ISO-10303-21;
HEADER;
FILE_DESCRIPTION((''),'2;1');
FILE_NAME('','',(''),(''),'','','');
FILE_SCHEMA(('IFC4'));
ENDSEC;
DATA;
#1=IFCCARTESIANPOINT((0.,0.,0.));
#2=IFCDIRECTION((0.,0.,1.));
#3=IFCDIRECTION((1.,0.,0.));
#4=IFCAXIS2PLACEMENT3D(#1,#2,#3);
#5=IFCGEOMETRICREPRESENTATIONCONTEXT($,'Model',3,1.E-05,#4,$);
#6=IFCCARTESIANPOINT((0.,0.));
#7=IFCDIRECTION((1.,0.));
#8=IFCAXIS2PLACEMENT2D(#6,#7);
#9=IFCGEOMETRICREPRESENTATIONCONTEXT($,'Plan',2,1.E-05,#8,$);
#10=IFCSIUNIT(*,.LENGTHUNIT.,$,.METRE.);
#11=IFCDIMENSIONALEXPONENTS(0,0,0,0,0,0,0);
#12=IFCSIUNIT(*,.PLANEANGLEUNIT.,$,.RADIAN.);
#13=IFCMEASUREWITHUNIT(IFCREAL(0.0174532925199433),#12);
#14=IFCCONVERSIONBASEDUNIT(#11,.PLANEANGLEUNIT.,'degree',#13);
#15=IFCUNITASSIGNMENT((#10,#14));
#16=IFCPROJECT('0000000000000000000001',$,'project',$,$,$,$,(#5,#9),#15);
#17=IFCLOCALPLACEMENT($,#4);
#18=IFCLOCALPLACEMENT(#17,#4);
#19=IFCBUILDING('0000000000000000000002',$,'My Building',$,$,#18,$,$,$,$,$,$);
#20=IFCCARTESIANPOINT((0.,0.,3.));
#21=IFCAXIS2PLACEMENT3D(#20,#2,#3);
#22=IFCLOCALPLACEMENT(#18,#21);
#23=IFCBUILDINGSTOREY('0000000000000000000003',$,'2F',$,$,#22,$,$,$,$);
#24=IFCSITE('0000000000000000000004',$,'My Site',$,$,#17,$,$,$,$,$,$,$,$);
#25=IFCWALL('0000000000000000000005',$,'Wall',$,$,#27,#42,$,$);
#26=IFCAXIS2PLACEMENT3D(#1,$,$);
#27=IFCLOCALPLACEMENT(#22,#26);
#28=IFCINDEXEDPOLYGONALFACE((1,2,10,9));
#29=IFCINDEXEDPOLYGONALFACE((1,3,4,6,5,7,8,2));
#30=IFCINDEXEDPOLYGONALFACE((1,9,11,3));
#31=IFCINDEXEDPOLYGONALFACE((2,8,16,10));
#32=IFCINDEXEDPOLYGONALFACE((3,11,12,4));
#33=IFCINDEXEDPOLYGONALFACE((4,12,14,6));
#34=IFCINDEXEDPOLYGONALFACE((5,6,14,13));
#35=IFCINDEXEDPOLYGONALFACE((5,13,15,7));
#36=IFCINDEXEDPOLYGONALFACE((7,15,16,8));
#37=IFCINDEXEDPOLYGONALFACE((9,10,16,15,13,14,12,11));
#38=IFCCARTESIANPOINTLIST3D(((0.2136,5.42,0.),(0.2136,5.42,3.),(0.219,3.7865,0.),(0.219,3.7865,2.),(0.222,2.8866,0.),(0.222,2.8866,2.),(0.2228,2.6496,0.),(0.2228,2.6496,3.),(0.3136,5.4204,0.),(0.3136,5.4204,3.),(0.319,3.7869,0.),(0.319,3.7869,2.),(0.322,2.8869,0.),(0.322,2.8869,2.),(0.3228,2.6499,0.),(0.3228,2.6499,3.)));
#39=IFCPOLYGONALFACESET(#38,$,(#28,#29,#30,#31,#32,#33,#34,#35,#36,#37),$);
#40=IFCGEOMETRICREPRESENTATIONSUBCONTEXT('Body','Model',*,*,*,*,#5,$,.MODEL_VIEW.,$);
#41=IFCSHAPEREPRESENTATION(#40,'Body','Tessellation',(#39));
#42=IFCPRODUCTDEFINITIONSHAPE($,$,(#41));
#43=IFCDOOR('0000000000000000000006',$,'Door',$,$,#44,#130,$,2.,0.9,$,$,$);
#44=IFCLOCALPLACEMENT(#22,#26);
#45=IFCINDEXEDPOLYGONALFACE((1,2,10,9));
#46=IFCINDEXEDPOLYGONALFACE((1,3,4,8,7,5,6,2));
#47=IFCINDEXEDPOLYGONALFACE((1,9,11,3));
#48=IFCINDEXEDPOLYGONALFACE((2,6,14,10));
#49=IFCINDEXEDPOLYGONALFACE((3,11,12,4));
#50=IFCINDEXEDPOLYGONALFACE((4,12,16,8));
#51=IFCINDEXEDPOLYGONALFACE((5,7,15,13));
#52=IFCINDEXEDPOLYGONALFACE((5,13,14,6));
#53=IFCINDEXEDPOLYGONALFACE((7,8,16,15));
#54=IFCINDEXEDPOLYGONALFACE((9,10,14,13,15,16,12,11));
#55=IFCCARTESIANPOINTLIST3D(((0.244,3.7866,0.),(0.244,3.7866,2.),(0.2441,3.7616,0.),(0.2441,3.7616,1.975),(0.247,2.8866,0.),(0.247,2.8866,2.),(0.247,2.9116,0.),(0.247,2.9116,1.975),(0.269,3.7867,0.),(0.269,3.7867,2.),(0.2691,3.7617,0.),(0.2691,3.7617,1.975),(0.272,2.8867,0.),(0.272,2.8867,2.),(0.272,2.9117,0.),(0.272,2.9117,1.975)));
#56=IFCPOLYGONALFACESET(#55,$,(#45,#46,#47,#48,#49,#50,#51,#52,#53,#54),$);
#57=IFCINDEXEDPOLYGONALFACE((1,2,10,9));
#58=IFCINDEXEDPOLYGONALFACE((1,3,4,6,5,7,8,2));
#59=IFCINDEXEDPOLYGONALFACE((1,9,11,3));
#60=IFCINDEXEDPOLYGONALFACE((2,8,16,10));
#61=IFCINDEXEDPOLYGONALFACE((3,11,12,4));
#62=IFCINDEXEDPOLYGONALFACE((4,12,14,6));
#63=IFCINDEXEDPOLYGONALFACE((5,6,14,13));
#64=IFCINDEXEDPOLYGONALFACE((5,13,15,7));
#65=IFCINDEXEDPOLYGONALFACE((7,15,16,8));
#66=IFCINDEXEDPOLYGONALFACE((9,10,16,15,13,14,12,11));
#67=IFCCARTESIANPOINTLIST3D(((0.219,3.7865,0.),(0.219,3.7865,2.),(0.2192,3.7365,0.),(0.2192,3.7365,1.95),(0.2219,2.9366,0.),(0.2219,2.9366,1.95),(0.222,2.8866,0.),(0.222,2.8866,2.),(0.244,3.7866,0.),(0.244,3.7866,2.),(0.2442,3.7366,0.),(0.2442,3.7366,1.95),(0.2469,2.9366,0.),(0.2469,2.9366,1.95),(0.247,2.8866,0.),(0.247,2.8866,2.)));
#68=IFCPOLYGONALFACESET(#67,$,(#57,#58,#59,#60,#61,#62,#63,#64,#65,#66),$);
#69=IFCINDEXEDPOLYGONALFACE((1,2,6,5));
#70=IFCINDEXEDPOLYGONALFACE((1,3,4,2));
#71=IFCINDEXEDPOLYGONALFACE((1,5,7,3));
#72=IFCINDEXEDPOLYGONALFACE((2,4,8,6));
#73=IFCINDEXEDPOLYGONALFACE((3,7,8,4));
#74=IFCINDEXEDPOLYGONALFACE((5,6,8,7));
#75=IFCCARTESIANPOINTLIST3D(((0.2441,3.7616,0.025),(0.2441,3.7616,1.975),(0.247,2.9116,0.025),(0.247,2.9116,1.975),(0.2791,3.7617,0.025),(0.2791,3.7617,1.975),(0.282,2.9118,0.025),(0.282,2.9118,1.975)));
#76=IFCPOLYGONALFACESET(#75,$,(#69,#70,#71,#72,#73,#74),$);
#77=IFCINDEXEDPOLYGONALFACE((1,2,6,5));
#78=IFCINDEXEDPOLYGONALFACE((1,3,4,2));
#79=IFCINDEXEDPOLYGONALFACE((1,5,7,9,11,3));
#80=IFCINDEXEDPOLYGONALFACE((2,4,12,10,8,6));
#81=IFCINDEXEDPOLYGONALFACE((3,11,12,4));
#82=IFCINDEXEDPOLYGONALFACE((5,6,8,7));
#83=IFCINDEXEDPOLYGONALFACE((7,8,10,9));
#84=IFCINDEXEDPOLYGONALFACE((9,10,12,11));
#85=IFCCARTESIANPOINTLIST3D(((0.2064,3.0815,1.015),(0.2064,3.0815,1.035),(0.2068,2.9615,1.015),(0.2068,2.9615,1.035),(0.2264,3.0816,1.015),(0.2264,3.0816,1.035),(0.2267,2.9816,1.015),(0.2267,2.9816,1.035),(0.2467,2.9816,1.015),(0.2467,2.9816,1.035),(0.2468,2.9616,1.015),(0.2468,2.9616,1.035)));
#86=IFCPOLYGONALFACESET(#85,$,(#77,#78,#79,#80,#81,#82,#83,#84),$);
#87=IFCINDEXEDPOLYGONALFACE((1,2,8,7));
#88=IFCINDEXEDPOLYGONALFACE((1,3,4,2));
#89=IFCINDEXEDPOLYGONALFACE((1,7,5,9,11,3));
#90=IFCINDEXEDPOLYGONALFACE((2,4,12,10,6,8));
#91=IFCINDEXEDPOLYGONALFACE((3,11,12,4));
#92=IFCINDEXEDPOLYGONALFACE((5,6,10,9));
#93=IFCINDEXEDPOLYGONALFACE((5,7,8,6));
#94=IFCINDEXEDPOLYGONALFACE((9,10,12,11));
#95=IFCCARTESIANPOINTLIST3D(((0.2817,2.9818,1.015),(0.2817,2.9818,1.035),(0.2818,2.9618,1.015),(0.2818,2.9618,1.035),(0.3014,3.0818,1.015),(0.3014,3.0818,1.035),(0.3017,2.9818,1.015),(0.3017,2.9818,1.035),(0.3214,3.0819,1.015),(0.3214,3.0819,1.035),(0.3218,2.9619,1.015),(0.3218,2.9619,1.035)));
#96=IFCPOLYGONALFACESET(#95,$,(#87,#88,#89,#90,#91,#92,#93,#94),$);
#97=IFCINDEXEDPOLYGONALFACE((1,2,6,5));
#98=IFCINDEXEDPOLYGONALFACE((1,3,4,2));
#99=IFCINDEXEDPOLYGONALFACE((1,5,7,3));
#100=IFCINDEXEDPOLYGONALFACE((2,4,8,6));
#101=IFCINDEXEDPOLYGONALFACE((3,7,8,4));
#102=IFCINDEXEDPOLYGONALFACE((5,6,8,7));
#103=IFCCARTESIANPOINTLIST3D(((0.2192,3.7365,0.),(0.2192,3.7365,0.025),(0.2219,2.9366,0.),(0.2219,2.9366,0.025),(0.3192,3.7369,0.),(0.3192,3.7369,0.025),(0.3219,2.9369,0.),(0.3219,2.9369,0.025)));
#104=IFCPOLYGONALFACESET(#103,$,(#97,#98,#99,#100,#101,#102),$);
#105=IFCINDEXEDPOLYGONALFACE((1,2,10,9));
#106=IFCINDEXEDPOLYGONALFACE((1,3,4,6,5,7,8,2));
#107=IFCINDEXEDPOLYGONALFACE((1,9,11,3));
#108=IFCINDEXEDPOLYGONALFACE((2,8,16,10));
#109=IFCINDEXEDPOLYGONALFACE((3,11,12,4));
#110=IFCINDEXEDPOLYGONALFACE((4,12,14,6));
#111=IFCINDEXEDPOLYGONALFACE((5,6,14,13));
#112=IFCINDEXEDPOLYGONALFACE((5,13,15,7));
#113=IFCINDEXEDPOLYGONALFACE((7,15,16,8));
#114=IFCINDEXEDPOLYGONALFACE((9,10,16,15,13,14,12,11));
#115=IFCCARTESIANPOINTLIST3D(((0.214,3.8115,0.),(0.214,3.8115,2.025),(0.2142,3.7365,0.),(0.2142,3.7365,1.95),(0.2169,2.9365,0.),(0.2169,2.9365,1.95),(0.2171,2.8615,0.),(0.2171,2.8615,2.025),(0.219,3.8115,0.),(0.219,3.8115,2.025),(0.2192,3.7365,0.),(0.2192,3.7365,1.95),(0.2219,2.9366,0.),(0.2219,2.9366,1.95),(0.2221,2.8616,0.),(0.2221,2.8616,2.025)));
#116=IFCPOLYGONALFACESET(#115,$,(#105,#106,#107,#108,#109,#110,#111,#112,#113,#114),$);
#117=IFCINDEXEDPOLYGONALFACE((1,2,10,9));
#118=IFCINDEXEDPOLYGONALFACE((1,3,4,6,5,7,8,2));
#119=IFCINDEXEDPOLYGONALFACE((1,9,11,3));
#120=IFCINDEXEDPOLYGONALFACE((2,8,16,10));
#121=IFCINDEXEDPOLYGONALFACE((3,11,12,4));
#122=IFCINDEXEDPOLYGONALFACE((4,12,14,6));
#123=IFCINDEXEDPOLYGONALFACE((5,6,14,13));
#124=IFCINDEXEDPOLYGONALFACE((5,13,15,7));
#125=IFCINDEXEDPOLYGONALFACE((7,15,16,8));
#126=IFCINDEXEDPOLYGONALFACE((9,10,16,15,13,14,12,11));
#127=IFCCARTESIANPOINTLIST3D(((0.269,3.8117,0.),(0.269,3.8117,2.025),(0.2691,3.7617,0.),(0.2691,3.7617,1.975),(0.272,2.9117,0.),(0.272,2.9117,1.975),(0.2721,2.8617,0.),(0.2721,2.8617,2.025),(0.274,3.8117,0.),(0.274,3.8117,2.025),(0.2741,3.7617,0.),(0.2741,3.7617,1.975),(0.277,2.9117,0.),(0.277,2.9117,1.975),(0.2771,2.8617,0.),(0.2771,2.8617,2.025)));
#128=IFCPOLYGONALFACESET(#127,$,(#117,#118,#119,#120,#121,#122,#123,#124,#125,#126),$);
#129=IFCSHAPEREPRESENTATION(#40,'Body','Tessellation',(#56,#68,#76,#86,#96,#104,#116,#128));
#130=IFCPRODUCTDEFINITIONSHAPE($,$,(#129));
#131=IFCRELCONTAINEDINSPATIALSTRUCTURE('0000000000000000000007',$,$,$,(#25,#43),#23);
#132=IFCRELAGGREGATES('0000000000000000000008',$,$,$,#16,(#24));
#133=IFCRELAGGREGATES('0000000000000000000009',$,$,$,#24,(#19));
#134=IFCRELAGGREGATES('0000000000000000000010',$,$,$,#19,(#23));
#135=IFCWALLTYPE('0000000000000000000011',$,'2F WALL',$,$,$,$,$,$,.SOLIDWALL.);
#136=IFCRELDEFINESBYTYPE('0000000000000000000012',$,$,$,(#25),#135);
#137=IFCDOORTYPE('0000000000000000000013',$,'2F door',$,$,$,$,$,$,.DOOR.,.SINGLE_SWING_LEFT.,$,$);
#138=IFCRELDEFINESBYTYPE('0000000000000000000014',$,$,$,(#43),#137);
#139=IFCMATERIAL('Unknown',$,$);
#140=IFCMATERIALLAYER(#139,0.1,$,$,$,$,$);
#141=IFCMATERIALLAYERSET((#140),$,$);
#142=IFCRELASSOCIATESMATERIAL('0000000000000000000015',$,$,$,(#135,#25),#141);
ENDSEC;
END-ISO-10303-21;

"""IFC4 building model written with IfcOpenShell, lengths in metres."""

from ifc_helpers import new_model, entity, si_unit, converted_unit, frame, origin_with_axes, origin_2d_with_axis, place, context, subcontext, project, spatial, line, indexed_curve, outline, extrude, shape, source, transform, mapped, material, layer, layer_set, layer_usage, type_object, type_shapes, element, fill, save


model = new_model("IFC4")

# Units and contexts
model_context = context("Model", 3, precision=1e-05, world=origin_with_axes())
plan_context = context("Plan", 2, precision=1e-05, world=origin_2d_with_axis())
body_context_1 = subcontext(model_context, "Body", "Model", "MODEL_VIEW")
body_context_2 = subcontext(plan_context, "Body", "Plan", "PLAN_VIEW")
ifc_project = project(units=[si_unit("LENGTHUNIT", "METRE"), converted_unit("PLANEANGLEUNIT", "degree", entity("IfcReal", 0.0174532925199433), si_unit("PLANEANGLEUNIT", "RADIAN"), dimensions=[0, 0, 0, 0, 0, 0, 0])], contexts=[model_context, plan_context])

# Site, building, storey
site_placement = place(None, origin_with_axes())
site = spatial("IfcSite", under=ifc_project, at=site_placement, Name="My Site")
building_placement = place(site_placement, origin_with_axes())
building = spatial("IfcBuilding", under=site, at=building_placement, Name="My Building")
storey_placement = place(building_placement, frame((0.0, 0.0, 3.0), z_axis=(0.0, 0.0, 1.0), x_axis=(1.0, 0.0, 0.0)))
storey = spatial("IfcBuildingStorey", under=building, at=storey_placement, Name="2F")

# Shared definitions
ifc_material = material(Name="Unknown")

# Shared definitions
ifc_layer_1 = layer(ifc_material, 0.1)
ifc_layer_set_1 = layer_set([ifc_layer_1])
wall_type = type_object("IfcWallType", Name="2F WALL", PredefinedType="SOLIDWALL", material=ifc_layer_set_1)

# Wall, opening, door
ifc_layer_usage_1 = layer_usage(ifc_layer_set_1, "AXIS2", "POSITIVE", 0.0)
wall_1_placement = place(storey_placement, frame((0.2136, 5.42, 0.0), z_axis=(0.0, 0.0, 1.0), x_axis=(0.003341, -0.999994, 0.0)))
wall_1 = element("IfcWall", 1, at=wall_1_placement, inside=storey, type_object=wall_type, material=ifc_layer_usage_1, Name="Wall", context=body_context_1, shape_type="SweptSolid", body=[
    extrude(outline(indexed_curve([(0.0, 0.0), (0.0, 0.1), (2.7705, 0.1), (2.7705, 0.0)], segments=[line(1, 2, 3, 4, 1)])), origin_with_axes(), (0.0, 0.0, 1.0), 3.0),
])
shared_shape_1 = source(origin_with_axes(), body_context_1, "Body", "SweptSolid", [
    extrude(outline(indexed_curve([(0.0, 0.0), (0.9, 0.0), (0.9, 2.0), (0.0, 2.0)], segments=[line(1, 2, 3, 4, 1)])), frame((0.0, -0.6, 0.0), z_axis=(0.0, -1.0, 0.0), x_axis=(1.0, 0.0, 0.0)), (0.0, 0.0, -1.0), 1.2),
])
opening_1_placement = place(wall_1_placement, frame((1.6335, 0.0, 0.0), z_axis=(0.0, 0.0, 1.0), x_axis=(1.0, 0.0, 0.0)))
opening_1 = element("IfcOpeningElement", 2, at=opening_1_placement, cuts=wall_1, PredefinedType="OPENING", context=body_context_1, shape_type="MappedRepresentation", body=[
    mapped(shared_shape_1, transform((0.0, 0.0, 0.0), x_axis=(1.0, 0.0, 0.0), y_axis=(0.0, 1.0, 0.0), z_axis=(0.0, 0.0, 1.0), scale=1.0)),
])
door_type = type_object("IfcDoorType", Name="2F door", OperationType="SINGLE_SWING_LEFT", PredefinedType="DOOR")
shared_shape_2 = source(origin_with_axes(), body_context_1, "Body", "SweptSolid", [
    extrude(outline(indexed_curve([(0.0, 0.0), (0.0, 2.0), (0.9, 2.0), (0.9, 0.0), (0.875, 0.0), (0.875, 1.975), (0.025, 1.975), (0.025, 0.0)], segments=[line(1, 2, 3, 4, 5, 6, 7, 8, 1)])), frame((0.0, 0.025, 0.0), z_axis=(0.0, -1.0, 0.0), x_axis=(1.0, 0.0, 0.0)), (0.0, 0.0, -1.0), 0.025),
    extrude(outline(indexed_curve([(0.0, 0.0), (0.0, 2.0), (0.9, 2.0), (0.9, 0.0), (0.85, 0.0), (0.85, 1.95), (0.05, 1.95), (0.05, 0.0)], segments=[line(1, 2, 3, 4, 5, 6, 7, 8, 1)])), frame((0.0, 0.0, 0.0), z_axis=(0.0, -1.0, 0.0), x_axis=(1.0, 0.0, 0.0)), (0.0, 0.0, -1.0), 0.025),
    extrude(outline(indexed_curve([(0.0, 0.0), (0.85, 0.0), (0.85, 0.035), (0.0, 0.035)], segments=[line(1, 2, 3, 4, 1)])), frame((0.025, 0.025, 0.025), z_axis=(0.0, 0.0, 1.0), x_axis=(1.0, 0.0, 0.0)), (0.0, 0.0, 1.0), 1.95),
    extrude(outline(indexed_curve([(0.0, 0.0), (0.0, -0.04), (-0.12, -0.04), (-0.12, -0.02), (-0.02, -0.02), (-0.02, 0.0)], segments=[line(1, 2, 3, 4, 5, 6, 1)])), frame((0.825, 0.025, 1.015), z_axis=(0.0, 0.0, 1.0), x_axis=(1.0, 0.0, 0.0)), (0.0, 0.0, 1.0), 0.02),
    extrude(outline(indexed_curve([(0.0, 0.0), (0.0, 0.04), (-0.12, 0.04), (-0.12, 0.02), (-0.02, 0.02), (-0.02, 0.0)], segments=[line(1, 2, 3, 4, 5, 6, 1)])), frame((0.825, 0.06, 1.015), z_axis=(0.0, 0.0, 1.0), x_axis=(1.0, 0.0, 0.0)), (0.0, 0.0, 1.0), 0.02),
    extrude(outline(indexed_curve([(0.0, 0.0), (0.8, 0.0), (0.8, 0.1), (0.0, 0.1)], segments=[line(1, 2, 3, 4, 1)])), frame((0.05, 0.0, 0.0), z_axis=(0.0, 0.0, 1.0), x_axis=(1.0, 0.0, 0.0)), (0.0, 0.0, 1.0), 0.025),
    extrude(outline(indexed_curve([(0.0, 0.0), (0.0, 2.025), (0.95, 2.025), (0.95, 0.0), (0.875, 0.0), (0.875, 1.95), (0.075, 1.95), (0.075, 0.0)], segments=[line(1, 2, 3, 4, 5, 6, 7, 8, 1)])), frame((-0.025, -0.005, 0.0), z_axis=(0.0, -1.0, 0.0), x_axis=(1.0, 0.0, 0.0)), (0.0, 0.0, -1.0), 0.005),
    extrude(outline(indexed_curve([(0.0, 0.0), (0.0, 2.025), (0.95, 2.025), (0.95, 0.0), (0.9, 0.0), (0.9, 1.975), (0.05, 1.975), (0.05, 0.0)], segments=[line(1, 2, 3, 4, 5, 6, 7, 8, 1)])), frame((-0.025, 0.05, 0.0), z_axis=(0.0, -1.0, 0.0), x_axis=(1.0, 0.0, 0.0)), (0.0, 0.0, -1.0), 0.005),
])
shared_shape_3 = source(origin_with_axes(), body_context_2, "Body", "Curve2D", [
    entity("IfcIndexedPolyCurve", entity("IfcCartesianPointList2D", [[0.0, 0.0], [0.0, 0.05], [0.025, 0.05], [0.025, 0.025], [0.05, 0.025], [0.05, 0.0]]), [entity("IfcLineIndex", [1, 2, 3, 4, 5, 6, 1])]),
    entity("IfcIndexedPolyCurve", entity("IfcCartesianPointList2D", [[0.9, 0.0], [0.9, 0.05], [0.875, 0.05], [0.875, 0.025], [0.85, 0.025], [0.85, 0.0]]), [entity("IfcLineIndex", [1, 2, 3, 4, 5, 6, 1])]),
    entity("IfcTrimmedCurve", entity("IfcEllipse", entity("IfcAxis2Placement2D", entity("IfcCartesianPoint", [0.06, 0.05]), entity("IfcDirection", [1.0, 0.0])), 0.815, 0.85), [entity("IfcCartesianPoint", [0.875, 0.05])], [entity("IfcCartesianPoint", [0.06, 0.9])], True, "CARTESIAN"),
    entity("IfcIndexedPolyCurve", entity("IfcCartesianPointList2D", [[0.025, 0.05], [0.06, 0.05], [0.06, 0.9], [0.025, 0.9]]), [entity("IfcLineIndex", [1, 2, 3, 4, 1])]),
])
type_shapes(door_type, [shared_shape_2, shared_shape_3])
door_1_placement = place(opening_1_placement, frame((0.0, 0.0, 0.0), z_axis=(0.0, 0.0, 1.0), x_axis=(1.0, 0.0, 0.0)))
door_1 = element("IfcDoor", 3, at=door_1_placement, inside=storey, type_object=door_type, Name="Door", OverallHeight=2.0, OverallWidth=0.9, shapes=[
    shape(body_context_1, "Body", "MappedRepresentation", [mapped(shared_shape_2, transform((0.0, 0.0, 0.0), x_axis=(1.0, 0.0, 0.0), y_axis=(0.0, 1.0, 0.0), z_axis=(0.0, 0.0, 1.0), scale=1.0))]),
    shape(body_context_2, "Body", "MappedRepresentation", [mapped(shared_shape_3, transform((0.0, 0.0, 0.0), x_axis=(1.0, 0.0, 0.0), y_axis=(0.0, 1.0, 0.0), z_axis=(0.0, 0.0, 1.0), scale=1.0))]),
])
fill(opening_1, door_1)

save(model, "model.ifc")
